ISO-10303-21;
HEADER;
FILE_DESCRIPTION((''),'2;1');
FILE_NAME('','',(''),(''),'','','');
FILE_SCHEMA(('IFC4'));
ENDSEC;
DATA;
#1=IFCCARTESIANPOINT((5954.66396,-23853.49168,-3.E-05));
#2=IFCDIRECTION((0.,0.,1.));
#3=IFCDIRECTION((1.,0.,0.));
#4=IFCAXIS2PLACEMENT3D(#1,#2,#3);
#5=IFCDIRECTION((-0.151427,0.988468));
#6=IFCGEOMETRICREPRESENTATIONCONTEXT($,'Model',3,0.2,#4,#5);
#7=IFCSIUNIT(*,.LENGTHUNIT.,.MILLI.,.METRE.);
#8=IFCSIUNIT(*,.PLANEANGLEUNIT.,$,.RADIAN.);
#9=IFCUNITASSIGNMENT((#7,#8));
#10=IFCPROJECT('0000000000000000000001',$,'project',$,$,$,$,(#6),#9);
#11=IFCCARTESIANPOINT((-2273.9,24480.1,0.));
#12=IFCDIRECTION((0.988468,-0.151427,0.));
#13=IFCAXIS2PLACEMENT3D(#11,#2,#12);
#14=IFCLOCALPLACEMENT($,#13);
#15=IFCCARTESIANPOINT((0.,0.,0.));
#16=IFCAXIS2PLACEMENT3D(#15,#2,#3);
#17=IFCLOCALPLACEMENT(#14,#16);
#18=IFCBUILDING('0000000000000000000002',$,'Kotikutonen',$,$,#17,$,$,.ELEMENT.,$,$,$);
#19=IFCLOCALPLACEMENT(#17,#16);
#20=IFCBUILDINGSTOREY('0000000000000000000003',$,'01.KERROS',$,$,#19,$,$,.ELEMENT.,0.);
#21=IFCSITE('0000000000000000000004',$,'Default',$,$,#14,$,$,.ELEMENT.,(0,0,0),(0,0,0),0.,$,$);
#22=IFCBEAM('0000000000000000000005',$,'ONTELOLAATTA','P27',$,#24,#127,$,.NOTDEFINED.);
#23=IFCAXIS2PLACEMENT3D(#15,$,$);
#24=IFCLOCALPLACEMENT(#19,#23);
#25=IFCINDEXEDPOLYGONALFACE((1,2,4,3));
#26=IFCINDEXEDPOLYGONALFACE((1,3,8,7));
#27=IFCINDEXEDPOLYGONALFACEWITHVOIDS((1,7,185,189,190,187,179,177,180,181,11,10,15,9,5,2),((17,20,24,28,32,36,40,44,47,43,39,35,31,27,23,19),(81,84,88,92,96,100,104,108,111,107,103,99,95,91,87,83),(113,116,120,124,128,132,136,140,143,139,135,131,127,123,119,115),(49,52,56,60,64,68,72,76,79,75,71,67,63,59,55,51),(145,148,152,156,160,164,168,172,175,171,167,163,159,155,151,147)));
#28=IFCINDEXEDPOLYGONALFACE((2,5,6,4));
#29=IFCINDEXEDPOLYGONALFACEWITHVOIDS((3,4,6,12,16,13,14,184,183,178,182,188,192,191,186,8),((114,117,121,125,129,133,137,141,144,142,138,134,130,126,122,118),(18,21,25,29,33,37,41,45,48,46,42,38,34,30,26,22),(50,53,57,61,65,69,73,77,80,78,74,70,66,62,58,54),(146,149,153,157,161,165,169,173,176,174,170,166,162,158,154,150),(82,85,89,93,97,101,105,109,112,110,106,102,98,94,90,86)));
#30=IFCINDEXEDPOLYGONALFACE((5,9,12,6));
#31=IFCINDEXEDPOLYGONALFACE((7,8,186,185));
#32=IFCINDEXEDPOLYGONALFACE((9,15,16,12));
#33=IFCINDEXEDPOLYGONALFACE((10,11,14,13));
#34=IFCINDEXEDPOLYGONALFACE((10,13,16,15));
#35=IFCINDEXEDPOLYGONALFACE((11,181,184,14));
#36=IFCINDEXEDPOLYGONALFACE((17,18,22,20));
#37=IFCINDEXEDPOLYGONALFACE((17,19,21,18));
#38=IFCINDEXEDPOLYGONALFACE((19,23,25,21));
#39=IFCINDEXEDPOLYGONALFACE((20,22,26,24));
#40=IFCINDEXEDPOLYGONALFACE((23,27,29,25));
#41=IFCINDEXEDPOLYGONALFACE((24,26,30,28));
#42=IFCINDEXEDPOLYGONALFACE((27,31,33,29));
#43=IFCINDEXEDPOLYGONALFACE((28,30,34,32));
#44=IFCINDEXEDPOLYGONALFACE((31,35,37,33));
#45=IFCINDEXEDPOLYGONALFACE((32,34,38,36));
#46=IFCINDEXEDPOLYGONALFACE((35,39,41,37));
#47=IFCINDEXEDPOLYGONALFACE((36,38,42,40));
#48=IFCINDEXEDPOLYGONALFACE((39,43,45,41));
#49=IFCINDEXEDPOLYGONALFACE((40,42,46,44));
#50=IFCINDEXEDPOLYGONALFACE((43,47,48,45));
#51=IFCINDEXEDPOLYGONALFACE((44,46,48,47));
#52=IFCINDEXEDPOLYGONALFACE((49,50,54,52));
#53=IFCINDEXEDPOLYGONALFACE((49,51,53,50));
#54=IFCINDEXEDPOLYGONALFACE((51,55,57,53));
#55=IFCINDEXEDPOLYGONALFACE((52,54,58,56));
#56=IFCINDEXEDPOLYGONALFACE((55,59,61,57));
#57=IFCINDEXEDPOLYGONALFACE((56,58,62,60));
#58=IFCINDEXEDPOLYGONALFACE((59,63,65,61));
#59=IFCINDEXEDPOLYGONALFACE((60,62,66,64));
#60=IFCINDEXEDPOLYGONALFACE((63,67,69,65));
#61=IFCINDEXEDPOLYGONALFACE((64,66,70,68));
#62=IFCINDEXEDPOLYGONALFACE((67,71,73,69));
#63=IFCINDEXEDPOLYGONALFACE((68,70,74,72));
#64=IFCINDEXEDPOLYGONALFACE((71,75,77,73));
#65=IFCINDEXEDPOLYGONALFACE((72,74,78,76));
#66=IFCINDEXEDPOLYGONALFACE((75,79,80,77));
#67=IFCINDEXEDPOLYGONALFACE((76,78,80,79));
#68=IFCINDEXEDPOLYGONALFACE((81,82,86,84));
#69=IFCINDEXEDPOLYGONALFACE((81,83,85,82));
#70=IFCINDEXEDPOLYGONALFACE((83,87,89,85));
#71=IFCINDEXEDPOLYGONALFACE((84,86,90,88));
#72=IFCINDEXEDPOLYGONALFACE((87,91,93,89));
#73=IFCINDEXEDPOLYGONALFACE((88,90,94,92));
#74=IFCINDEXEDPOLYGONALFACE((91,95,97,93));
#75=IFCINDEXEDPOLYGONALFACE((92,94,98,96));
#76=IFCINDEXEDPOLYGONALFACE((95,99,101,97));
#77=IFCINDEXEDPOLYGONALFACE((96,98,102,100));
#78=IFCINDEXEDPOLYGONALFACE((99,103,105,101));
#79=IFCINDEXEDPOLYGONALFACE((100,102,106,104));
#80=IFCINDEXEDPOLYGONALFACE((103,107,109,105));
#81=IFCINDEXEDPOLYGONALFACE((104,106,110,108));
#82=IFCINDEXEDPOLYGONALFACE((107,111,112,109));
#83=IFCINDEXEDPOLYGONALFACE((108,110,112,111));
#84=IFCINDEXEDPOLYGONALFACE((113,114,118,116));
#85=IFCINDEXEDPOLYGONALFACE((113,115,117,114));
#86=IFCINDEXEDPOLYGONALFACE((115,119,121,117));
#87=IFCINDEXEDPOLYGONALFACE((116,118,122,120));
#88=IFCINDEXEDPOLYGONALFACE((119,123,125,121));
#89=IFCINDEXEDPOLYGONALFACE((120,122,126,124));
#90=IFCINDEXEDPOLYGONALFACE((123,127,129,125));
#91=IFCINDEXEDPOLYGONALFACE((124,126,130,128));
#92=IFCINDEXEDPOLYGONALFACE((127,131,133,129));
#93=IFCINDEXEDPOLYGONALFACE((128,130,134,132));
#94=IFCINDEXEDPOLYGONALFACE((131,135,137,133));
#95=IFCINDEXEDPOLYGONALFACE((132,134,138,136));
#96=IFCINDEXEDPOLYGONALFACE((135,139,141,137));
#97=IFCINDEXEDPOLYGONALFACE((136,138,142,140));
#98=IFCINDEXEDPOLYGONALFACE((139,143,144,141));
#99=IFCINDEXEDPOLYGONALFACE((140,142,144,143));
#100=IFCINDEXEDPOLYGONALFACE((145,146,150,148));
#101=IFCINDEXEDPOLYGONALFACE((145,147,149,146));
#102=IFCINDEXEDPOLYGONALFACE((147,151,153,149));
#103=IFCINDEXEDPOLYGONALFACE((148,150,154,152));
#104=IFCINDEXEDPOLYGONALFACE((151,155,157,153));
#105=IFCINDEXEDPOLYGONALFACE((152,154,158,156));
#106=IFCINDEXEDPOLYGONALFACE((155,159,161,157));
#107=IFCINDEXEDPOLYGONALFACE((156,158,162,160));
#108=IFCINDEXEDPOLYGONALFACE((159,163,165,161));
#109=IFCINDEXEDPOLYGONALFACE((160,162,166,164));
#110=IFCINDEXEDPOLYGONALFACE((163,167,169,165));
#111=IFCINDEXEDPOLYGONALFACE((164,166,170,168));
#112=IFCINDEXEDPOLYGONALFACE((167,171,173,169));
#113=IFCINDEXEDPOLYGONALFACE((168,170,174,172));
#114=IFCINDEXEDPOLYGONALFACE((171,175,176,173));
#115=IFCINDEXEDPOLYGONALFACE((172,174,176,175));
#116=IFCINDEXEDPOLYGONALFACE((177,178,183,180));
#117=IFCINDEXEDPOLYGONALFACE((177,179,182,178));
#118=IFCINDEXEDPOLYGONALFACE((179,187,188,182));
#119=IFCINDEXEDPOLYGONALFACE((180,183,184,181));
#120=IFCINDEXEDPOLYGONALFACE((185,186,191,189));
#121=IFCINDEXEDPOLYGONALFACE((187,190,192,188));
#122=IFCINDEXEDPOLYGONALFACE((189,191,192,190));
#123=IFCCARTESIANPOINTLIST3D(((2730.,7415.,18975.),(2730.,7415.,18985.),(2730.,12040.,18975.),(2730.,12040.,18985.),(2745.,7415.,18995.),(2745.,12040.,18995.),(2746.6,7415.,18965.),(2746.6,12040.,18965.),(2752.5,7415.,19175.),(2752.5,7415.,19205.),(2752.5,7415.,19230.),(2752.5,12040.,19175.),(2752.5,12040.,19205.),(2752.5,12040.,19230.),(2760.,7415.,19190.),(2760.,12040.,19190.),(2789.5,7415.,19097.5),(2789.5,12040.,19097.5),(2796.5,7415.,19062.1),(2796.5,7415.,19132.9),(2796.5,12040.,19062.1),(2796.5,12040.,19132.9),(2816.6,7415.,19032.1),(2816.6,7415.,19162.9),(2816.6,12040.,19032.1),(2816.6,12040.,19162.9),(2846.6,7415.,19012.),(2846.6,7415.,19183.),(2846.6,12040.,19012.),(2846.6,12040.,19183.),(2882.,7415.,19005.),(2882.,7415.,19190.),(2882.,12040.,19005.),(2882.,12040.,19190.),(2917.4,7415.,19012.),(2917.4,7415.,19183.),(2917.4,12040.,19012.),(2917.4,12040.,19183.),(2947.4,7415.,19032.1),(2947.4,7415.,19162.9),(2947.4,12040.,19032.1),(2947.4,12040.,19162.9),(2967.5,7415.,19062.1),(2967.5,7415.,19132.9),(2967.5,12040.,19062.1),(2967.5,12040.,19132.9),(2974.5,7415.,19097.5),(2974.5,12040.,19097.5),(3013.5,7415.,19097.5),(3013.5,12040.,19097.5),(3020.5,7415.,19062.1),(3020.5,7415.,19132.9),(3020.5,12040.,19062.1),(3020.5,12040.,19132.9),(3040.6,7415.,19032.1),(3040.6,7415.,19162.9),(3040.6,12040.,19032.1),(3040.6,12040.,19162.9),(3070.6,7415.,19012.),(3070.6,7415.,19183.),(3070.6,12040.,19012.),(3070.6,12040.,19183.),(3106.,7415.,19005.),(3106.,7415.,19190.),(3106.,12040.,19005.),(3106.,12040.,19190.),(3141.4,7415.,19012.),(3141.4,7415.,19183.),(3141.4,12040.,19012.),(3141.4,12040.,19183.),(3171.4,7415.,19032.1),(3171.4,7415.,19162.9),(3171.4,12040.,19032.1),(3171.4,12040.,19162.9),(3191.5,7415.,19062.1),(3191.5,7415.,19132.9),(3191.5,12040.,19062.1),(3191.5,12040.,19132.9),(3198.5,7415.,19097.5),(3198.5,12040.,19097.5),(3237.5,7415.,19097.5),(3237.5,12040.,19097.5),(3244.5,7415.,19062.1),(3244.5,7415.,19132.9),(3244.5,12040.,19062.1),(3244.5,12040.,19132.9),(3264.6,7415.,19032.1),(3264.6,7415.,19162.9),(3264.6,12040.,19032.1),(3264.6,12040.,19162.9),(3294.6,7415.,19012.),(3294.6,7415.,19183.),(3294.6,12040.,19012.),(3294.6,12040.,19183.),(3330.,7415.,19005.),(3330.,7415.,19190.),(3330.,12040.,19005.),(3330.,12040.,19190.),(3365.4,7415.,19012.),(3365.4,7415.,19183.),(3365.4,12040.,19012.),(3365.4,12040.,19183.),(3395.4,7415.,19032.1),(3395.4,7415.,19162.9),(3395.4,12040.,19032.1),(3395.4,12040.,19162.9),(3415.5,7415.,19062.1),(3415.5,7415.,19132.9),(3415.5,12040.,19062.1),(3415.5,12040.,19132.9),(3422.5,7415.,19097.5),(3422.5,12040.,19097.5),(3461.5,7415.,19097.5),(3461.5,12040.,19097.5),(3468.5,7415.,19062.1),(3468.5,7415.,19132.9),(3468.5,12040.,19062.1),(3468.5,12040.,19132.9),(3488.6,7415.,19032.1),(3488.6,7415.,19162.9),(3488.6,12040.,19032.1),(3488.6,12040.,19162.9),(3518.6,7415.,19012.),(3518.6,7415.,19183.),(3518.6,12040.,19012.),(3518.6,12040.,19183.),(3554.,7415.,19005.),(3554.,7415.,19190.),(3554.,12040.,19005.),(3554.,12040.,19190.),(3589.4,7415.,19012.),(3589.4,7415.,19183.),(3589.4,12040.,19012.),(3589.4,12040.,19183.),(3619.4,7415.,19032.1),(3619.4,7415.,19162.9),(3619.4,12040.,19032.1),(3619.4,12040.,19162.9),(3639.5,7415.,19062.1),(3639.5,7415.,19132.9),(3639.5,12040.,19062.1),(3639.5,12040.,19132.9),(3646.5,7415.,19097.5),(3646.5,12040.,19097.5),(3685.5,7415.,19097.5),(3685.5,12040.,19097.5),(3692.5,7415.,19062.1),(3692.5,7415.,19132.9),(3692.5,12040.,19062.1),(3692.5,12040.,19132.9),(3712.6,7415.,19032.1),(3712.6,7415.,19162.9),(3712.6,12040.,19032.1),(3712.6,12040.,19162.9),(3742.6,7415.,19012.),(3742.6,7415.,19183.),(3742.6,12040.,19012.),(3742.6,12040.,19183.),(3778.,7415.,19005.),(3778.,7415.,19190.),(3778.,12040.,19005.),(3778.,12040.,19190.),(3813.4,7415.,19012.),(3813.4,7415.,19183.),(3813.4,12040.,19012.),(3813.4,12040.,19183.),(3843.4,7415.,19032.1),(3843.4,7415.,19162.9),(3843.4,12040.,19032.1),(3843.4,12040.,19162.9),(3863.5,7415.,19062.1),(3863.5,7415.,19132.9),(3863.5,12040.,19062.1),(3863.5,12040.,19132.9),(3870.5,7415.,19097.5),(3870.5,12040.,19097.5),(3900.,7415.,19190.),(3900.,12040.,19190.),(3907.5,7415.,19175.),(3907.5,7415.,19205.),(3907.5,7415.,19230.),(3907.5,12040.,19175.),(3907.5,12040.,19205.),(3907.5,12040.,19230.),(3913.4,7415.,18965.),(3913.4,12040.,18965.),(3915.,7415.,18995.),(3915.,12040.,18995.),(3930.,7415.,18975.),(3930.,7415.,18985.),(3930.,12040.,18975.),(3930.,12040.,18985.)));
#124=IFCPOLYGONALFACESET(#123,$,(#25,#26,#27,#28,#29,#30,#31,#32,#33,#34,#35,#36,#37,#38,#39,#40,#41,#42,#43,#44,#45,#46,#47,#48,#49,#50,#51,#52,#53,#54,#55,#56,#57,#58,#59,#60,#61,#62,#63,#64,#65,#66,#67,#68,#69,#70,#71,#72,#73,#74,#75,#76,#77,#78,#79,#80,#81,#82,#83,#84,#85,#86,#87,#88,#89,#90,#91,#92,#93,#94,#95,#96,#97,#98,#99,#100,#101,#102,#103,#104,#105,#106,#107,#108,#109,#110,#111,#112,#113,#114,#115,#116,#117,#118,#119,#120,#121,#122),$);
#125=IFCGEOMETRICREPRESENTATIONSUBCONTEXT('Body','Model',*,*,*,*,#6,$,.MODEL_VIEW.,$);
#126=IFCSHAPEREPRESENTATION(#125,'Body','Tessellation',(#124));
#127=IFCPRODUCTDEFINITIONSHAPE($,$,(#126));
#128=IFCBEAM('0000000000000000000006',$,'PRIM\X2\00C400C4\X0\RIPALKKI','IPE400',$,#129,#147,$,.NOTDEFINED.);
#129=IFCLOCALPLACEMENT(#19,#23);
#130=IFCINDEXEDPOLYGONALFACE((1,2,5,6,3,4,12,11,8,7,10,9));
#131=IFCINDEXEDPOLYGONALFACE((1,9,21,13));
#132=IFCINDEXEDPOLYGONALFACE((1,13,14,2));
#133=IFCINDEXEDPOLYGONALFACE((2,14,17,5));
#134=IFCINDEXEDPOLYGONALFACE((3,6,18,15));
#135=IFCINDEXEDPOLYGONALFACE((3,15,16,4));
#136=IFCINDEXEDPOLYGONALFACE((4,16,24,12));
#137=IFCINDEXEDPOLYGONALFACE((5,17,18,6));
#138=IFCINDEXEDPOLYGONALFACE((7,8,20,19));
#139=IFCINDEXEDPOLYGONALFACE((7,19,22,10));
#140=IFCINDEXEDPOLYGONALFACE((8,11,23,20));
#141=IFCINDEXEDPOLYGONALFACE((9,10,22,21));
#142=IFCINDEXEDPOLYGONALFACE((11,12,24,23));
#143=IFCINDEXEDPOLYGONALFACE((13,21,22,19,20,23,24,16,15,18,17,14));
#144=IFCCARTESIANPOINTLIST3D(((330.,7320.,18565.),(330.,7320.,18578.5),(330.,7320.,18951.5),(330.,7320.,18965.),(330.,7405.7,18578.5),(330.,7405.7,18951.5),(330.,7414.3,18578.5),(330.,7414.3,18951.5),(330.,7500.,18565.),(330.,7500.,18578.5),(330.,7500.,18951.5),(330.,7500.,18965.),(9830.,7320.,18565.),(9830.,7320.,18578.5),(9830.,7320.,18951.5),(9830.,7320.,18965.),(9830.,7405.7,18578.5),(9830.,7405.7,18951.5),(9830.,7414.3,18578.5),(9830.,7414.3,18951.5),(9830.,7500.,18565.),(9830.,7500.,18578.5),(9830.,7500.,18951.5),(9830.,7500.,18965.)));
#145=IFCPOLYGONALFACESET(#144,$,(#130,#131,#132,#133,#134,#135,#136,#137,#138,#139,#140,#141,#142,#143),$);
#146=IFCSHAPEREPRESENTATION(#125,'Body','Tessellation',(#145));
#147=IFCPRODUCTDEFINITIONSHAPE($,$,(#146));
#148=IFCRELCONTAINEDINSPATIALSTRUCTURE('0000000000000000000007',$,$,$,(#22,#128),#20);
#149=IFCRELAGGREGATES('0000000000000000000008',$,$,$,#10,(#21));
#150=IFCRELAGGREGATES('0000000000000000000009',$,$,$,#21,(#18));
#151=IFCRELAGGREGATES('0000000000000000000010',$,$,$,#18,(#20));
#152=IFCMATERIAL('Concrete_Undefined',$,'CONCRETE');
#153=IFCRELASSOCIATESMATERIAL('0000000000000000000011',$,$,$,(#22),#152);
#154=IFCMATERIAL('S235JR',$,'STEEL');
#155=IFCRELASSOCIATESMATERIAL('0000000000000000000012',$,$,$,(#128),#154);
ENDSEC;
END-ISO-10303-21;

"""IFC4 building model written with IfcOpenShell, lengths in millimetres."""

from ifc_helpers import new_model, si_unit, direction, frame, origin_with_axes, place, context, subcontext, project, spatial, line, indexed_curve, outline, extrude, material, element, save


model = new_model("IFC4")

# Units and contexts
model_context = context("Model", 3, precision=0.2, world=frame((5954.66396, -23853.49168, -3e-05), z_axis=(0.0, 0.0, 1.0), x_axis=(1.0, 0.0, 0.0)), true_north=direction((-0.151427, 0.988468)))
body_context = subcontext(model_context, "Body", "Model", "MODEL_VIEW")
ifc_project = project(units=[si_unit("LENGTHUNIT", "METRE", prefix="MILLI"), si_unit("PLANEANGLEUNIT", "RADIAN")], contexts=[model_context])

# Site, building, storey
site_placement = place(None, frame((-2273.9, 24480.1, 0.0), z_axis=(0.0, 0.0, 1.0), x_axis=(0.988468, -0.151427, 0.0)))
site = spatial("IfcSite", under=ifc_project, at=site_placement, Name="Default", CompositionType="ELEMENT", RefLatitude=(0, 0, 0), RefLongitude=(0, 0, 0), RefElevation=0.0)
building_placement = place(site_placement, origin_with_axes())
building = spatial("IfcBuilding", under=site, at=building_placement, Name="Kotikutonen", CompositionType="ELEMENT")
storey_placement = place(building_placement, origin_with_axes())
storey = spatial("IfcBuildingStorey", under=building, at=storey_placement, Name="01.KERROS", CompositionType="ELEMENT", Elevation=0.0)

# Shared definitions
ifc_material_1 = material(Name="Concrete_Undefined", Category="CONCRETE")

# Beams
beam_1_placement = place(storey_placement, frame((3330.0, 12040.0, 19097.5), z_axis=(-1.0, 0.0, 0.0), x_axis=(0.0, -1.0, 0.0)))
element("IfcBeam", 1, at=beam_1_placement, inside=storey, material=ifc_material_1, Name="ONTELOLAATTA", Description="P27", PredefinedType="NOTDEFINED", context=body_context, shape_type="SolidModel", body=[
    extrude(outline(indexed_curve([(-600.0, -122.5), (-583.4, -132.5), (583.4, -132.5), (600.0, -122.5), (600.0, -112.5), (585.0, -102.5), (577.5, 77.5), (570.0, 92.5), (577.5, 107.5), (577.5, 132.5), (-577.5, 132.5), (-577.5, 107.5), (-570.0, 92.5), (-577.5, 77.5), (-585.0, -102.5), (-600.0, -112.5)], segments=[line(1, 2, 3, 4, 5, 6, 7, 8, 9, 10, 11, 12, 13, 14, 15, 16, 1)]), holes=[indexed_curve([(-448.0, -92.5), (-483.4, -85.5), (-513.4, -65.4), (-533.5, -35.4), (-540.5, 0.0), (-533.5, 35.4), (-513.4, 65.4), (-483.4, 85.5), (-448.0, 92.5), (-412.6, 85.5), (-382.6, 65.4), (-362.5, 35.4), (-355.5, 0.0), (-362.5, -35.4), (-382.6, -65.4), (-412.6, -85.5)], segments=[line(1, 2, 3, 4, 5, 6, 7, 8, 9, 10, 11, 12, 13, 14, 15, 16, 1)]), indexed_curve([(-224.0, -92.5), (-259.4, -85.5), (-289.4, -65.4), (-309.5, -35.4), (-316.5, 0.0), (-309.5, 35.4), (-289.4, 65.4), (-259.4, 85.5), (-224.0, 92.5), (-188.6, 85.5), (-158.6, 65.4), (-138.5, 35.4), (-131.5, 0.0), (-138.5, -35.4), (-158.6, -65.4), (-188.6, -85.5)], segments=[line(1, 2, 3, 4, 5, 6, 7, 8, 9, 10, 11, 12, 13, 14, 15, 16, 1)]), indexed_curve([(0.0, -92.5), (-35.4, -85.5), (-65.4, -65.4), (-85.5, -35.4), (-92.5, 0.0), (-85.5, 35.4), (-65.4, 65.4), (-35.4, 85.5), (0.0, 92.5), (35.4, 85.5), (65.4, 65.4), (85.5, 35.4), (92.5, 0.0), (85.5, -35.4), (65.4, -65.4), (35.4, -85.5)], segments=[line(1, 2, 3, 4, 5, 6, 7, 8, 9, 10, 11, 12, 13, 14, 15, 16, 1)]), indexed_curve([(224.0, -92.5), (188.6, -85.5), (158.6, -65.4), (138.5, -35.4), (131.5, 0.0), (138.5, 35.4), (158.6, 65.4), (188.6, 85.5), (224.0, 92.5), (259.4, 85.5), (289.4, 65.4), (309.5, 35.4), (316.5, 0.0), (309.5, -35.4), (289.4, -65.4), (259.4, -85.5)], segments=[line(1, 2, 3, 4, 5, 6, 7, 8, 9, 10, 11, 12, 13, 14, 15, 16, 1)]), indexed_curve([(448.0, -92.5), (412.6, -85.5), (382.6, -65.4), (362.5, -35.4), (355.5, 0.0), (362.5, 35.4), (382.6, 65.4), (412.6, 85.5), (448.0, 92.5), (483.4, 85.5), (513.4, 65.4), (533.5, 35.4), (540.5, 0.0), (533.5, -35.4), (513.4, -65.4), (483.4, -85.5)], segments=[line(1, 2, 3, 4, 5, 6, 7, 8, 9, 10, 11, 12, 13, 14, 15, 16, 1)])]), frame((0.0, 0.0, 0.0), z_axis=(-1.0, 0.0, 0.0), x_axis=(0.0, 0.0, 1.0)), (0.0, 0.0, -1.0), 4625.0),
])
ifc_material_2 = material(Name="S235JR", Category="STEEL")
beam_2_placement = place(storey_placement, frame((330.0, 7410.0, 18765.0), z_axis=(0.0, -1.0, 0.0), x_axis=(1.0, 0.0, 0.0)))
element("IfcBeam", 2, at=beam_2_placement, inside=storey, material=ifc_material_2, Name="PRIMÄÄRIPALKKI", Description="IPE400", PredefinedType="NOTDEFINED", context=body_context, shape_type="SolidModel", body=[
    extrude(outline(indexed_curve([(-90.0, -200.0), (90.0, -200.0), (90.0, -186.5), (4.3, -186.5), (4.3, 186.5), (90.0, 186.5), (90.0, 200.0), (-90.0, 200.0), (-90.0, 186.5), (-4.3, 186.5), (-4.3, -186.5), (-90.0, -186.5)], segments=[line(1, 2, 3, 4, 5, 6, 7, 8, 9, 10, 11, 12, 1)])), frame((0.0, 0.0, 0.0), z_axis=(-1.0, 0.0, 0.0), x_axis=(0.0, 0.0, 1.0)), (0.0, 0.0, -1.0), 9500.0),
])

save(model, "model.ifc")
